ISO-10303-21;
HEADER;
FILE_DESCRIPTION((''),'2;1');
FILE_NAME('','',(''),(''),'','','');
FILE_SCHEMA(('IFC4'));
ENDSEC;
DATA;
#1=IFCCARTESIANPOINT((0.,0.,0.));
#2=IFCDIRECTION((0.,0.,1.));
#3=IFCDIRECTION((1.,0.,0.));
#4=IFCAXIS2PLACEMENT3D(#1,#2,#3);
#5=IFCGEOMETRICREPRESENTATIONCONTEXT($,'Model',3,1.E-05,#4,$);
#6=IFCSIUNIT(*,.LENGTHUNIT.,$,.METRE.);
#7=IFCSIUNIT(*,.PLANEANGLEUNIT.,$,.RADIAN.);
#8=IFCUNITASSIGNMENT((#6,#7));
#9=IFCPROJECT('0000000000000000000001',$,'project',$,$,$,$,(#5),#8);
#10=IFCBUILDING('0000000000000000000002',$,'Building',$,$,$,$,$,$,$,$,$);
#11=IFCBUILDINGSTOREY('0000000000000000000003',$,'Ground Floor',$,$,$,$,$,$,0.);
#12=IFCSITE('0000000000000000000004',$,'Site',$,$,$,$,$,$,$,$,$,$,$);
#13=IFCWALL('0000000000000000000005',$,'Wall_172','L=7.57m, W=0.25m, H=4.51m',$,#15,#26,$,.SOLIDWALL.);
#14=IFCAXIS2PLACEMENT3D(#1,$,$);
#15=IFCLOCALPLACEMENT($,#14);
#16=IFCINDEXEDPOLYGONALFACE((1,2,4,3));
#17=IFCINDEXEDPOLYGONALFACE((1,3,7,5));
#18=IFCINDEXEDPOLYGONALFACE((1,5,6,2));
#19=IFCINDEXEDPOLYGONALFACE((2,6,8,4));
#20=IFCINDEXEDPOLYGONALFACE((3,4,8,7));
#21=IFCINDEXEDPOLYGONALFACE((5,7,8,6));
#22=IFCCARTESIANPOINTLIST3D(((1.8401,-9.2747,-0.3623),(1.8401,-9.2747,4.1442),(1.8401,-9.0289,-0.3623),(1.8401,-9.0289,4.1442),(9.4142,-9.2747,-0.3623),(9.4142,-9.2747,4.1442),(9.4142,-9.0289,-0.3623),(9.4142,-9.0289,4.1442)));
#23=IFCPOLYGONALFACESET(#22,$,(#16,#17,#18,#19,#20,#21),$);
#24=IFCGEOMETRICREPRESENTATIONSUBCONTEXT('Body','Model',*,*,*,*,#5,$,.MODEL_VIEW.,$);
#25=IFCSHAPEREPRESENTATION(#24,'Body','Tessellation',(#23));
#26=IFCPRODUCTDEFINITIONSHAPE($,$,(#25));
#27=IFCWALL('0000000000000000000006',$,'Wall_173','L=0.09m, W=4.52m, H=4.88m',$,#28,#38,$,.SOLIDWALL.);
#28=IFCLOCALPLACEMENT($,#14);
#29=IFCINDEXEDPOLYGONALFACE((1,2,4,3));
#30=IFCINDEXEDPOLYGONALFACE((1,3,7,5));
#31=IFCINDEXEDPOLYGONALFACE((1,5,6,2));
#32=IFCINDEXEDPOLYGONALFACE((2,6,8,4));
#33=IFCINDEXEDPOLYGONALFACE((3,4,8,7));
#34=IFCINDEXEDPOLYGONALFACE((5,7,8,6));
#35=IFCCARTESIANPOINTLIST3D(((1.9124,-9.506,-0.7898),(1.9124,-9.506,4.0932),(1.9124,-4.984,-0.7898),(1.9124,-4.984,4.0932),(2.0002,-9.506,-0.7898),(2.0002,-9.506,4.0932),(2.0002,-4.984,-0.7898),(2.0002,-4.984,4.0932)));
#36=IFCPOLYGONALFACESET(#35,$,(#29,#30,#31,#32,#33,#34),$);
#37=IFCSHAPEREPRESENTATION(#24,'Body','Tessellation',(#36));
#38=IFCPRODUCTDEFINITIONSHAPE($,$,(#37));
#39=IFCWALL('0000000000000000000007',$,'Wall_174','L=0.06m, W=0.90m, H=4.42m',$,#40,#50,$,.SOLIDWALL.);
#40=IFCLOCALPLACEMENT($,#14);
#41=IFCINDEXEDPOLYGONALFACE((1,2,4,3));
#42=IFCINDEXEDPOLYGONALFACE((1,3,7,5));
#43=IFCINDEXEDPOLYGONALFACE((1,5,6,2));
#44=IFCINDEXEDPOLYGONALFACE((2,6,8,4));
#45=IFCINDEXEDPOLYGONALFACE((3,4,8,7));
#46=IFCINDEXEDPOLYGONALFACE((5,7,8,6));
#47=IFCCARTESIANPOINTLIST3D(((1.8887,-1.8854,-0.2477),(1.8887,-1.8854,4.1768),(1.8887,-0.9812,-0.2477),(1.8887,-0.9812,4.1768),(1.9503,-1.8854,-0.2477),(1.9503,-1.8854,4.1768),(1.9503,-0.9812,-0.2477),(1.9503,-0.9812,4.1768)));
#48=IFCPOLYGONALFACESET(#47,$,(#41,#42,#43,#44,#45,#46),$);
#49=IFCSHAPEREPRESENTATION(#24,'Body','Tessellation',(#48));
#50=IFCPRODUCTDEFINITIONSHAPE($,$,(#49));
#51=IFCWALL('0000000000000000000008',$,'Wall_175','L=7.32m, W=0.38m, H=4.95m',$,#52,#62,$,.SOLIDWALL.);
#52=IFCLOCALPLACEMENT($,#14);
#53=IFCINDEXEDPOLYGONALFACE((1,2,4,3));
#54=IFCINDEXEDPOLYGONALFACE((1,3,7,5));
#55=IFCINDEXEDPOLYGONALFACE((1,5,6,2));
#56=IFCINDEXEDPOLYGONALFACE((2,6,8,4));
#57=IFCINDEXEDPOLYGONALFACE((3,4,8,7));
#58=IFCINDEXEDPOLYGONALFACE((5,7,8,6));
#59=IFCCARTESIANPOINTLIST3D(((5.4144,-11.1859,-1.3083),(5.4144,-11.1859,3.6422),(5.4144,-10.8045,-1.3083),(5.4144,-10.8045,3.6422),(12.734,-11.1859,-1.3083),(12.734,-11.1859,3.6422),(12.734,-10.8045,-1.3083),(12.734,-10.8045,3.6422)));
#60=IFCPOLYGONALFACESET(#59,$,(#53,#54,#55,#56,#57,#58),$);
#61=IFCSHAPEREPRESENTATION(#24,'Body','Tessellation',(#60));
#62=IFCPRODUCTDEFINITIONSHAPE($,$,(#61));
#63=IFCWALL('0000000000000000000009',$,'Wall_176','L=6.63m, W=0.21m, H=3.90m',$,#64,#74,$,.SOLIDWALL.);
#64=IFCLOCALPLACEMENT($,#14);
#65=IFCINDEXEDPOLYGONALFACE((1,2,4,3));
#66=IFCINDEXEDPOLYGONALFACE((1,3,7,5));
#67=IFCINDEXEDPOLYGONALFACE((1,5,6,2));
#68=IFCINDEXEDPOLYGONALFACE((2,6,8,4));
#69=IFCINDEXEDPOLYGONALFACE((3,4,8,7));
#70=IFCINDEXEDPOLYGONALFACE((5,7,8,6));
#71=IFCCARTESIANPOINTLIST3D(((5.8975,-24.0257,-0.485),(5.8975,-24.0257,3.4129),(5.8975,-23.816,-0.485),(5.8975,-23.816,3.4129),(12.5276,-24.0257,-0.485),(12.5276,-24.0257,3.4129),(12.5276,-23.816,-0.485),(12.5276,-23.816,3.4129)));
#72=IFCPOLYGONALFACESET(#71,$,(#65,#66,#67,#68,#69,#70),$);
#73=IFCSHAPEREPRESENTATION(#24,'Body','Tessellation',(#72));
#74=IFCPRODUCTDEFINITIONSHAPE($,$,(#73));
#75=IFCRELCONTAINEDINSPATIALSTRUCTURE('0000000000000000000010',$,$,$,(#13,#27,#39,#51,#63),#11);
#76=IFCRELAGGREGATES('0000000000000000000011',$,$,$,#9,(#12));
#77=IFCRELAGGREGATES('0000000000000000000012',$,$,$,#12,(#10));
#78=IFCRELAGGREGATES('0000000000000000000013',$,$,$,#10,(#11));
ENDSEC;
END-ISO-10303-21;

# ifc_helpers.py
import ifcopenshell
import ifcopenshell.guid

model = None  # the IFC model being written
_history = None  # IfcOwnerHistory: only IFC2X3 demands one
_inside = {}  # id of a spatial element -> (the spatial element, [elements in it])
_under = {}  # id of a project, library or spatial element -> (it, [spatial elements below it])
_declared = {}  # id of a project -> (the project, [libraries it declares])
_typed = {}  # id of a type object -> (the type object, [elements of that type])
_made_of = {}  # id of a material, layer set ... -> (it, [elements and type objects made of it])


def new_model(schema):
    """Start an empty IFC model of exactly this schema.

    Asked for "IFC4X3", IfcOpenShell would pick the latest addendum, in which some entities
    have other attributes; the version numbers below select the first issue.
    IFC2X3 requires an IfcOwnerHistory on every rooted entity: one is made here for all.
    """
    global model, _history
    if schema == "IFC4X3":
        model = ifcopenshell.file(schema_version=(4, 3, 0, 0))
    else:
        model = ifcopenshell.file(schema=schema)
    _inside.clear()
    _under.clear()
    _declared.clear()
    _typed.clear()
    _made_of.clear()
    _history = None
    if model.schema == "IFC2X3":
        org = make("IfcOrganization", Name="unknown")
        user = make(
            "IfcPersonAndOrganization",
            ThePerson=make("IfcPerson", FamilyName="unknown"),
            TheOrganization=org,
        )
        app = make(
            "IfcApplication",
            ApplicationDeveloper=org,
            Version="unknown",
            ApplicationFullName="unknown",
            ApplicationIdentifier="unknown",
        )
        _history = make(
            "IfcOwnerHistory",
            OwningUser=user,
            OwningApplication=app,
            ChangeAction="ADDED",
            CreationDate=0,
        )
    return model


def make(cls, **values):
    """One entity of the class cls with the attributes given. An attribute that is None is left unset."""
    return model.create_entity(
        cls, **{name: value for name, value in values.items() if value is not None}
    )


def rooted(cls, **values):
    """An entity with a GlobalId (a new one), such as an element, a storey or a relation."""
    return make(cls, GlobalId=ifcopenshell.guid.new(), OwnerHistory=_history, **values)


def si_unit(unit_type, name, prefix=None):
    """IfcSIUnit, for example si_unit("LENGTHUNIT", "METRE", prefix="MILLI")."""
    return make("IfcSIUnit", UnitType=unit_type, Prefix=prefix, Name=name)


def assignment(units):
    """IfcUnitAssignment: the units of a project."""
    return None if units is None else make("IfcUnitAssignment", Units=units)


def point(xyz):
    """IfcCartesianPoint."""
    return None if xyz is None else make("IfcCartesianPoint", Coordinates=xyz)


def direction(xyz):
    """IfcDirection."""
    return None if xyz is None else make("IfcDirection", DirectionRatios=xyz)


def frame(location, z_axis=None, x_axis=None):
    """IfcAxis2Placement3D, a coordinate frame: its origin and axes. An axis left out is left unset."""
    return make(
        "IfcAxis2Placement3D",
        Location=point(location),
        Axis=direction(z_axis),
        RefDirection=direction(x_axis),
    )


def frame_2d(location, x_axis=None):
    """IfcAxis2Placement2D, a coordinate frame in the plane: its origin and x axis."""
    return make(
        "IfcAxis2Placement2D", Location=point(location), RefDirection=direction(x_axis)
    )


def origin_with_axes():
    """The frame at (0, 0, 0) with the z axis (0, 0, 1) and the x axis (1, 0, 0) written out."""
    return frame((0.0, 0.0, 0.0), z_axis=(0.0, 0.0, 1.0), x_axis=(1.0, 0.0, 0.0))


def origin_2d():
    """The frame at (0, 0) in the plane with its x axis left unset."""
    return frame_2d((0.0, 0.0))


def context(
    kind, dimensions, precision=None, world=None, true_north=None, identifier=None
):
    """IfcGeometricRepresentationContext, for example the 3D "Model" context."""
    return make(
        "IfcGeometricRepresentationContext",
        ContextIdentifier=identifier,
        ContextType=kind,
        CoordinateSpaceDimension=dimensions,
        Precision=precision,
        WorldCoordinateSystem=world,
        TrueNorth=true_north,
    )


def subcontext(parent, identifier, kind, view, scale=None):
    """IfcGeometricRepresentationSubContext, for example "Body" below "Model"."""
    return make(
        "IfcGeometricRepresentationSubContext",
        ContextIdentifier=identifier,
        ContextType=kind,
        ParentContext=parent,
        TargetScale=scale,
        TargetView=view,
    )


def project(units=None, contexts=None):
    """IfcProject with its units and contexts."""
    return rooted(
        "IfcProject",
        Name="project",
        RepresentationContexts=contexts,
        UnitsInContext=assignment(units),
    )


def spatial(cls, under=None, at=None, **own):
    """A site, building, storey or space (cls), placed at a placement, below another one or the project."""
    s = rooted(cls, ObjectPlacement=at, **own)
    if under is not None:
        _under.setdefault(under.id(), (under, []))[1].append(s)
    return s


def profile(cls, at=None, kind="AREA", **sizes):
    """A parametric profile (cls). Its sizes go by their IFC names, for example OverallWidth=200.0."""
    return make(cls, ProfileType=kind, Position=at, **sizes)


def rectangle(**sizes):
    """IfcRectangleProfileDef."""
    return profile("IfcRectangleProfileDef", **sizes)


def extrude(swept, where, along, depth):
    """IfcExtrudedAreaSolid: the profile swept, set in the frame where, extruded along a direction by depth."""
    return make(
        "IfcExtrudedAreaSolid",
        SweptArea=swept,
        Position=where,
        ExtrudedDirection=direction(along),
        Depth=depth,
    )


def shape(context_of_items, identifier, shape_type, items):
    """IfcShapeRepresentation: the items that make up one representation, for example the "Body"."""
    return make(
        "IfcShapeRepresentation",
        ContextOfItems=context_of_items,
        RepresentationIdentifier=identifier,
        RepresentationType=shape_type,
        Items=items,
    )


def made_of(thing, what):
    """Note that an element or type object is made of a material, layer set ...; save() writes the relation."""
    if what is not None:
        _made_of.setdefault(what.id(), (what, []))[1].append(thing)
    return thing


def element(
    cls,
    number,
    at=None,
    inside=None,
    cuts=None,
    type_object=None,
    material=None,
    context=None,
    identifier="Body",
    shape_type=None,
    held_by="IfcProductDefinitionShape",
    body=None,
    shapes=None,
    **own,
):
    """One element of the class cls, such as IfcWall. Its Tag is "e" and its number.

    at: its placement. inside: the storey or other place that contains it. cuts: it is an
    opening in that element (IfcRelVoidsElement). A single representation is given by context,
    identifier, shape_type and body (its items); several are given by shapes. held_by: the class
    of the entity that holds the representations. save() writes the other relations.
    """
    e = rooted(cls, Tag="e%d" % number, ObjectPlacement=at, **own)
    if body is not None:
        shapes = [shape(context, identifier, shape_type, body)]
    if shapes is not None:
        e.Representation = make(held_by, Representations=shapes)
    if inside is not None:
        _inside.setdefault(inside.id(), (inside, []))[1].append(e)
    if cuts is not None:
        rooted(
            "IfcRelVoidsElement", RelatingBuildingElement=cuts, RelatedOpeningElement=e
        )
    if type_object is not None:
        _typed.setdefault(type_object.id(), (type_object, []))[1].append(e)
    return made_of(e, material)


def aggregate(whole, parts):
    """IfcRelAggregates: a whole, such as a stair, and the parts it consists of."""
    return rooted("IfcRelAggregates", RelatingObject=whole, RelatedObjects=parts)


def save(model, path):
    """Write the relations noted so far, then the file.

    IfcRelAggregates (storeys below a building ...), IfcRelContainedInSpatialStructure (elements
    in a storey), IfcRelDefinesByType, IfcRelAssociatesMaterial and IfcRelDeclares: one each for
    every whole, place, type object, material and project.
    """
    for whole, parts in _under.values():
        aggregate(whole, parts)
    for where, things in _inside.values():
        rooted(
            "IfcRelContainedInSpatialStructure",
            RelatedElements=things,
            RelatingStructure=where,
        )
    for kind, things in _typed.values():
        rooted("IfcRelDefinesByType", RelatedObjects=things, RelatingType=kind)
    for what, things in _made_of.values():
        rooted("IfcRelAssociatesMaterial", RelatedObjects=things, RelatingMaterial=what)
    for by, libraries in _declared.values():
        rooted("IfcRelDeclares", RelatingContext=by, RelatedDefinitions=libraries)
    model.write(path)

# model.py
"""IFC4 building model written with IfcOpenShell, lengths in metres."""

from ifc_helpers import new_model, si_unit, frame, origin_with_axes, origin_2d, context, subcontext, project, spatial, rectangle, extrude, element, save


model = new_model("IFC4")

# Units and contexts
model_context = context("Model", 3, precision=1e-05, world=origin_with_axes())
body_context = subcontext(model_context, "Body", "Model", "MODEL_VIEW")
ifc_project = project(units=[si_unit("LENGTHUNIT", "METRE"), si_unit("PLANEANGLEUNIT", "RADIAN")], contexts=[model_context])

# Site, building, storey
site = spatial("IfcSite", under=ifc_project, Name="Site")
building = spatial("IfcBuilding", under=site, Name="Building")
storey = spatial("IfcBuildingStorey", under=building, Name="Ground Floor", Elevation=0.0)

# Walls
element("IfcWall", 1, inside=storey, Name="Wall_172", Description="L=7.57m, W=0.25m, H=4.51m", PredefinedType="SOLIDWALL", context=body_context, shape_type="SweptSolid", body=[
    extrude(rectangle(XDim=7.574, YDim=0.2458, at=origin_2d()), frame((5.6272, -9.1518, -0.3623), z_axis=(0.0, 0.0, 1.0), x_axis=(1.0, 0.0, 0.0)), (0.0, 0.0, 1.0), 4.5066),
])
element("IfcWall", 2, inside=storey, Name="Wall_173", Description="L=0.09m, W=4.52m, H=4.88m", PredefinedType="SOLIDWALL", context=body_context, shape_type="SweptSolid", body=[
    extrude(rectangle(XDim=0.0879, YDim=4.522, at=origin_2d()), frame((1.9563, -7.245, -0.7898), z_axis=(0.0, 0.0, 1.0), x_axis=(1.0, 0.0, 0.0)), (0.0, 0.0, 1.0), 4.883),
])
element("IfcWall", 3, inside=storey, Name="Wall_174", Description="L=0.06m, W=0.90m, H=4.42m", PredefinedType="SOLIDWALL", context=body_context, shape_type="SweptSolid", body=[
    extrude(rectangle(XDim=0.0616, YDim=0.9042, at=origin_2d()), frame((1.9195, -1.4333, -0.2477), z_axis=(0.0, 0.0, 1.0), x_axis=(1.0, 0.0, 0.0)), (0.0, 0.0, 1.0), 4.4245),
])
element("IfcWall", 4, inside=storey, Name="Wall_175", Description="L=7.32m, W=0.38m, H=4.95m", PredefinedType="SOLIDWALL", context=body_context, shape_type="SweptSolid", body=[
    extrude(rectangle(XDim=7.3196, YDim=0.3814, at=origin_2d()), frame((9.0742, -10.9952, -1.3083), z_axis=(0.0, 0.0, 1.0), x_axis=(1.0, 0.0, 0.0)), (0.0, 0.0, 1.0), 4.9505),
])
element("IfcWall", 5, inside=storey, Name="Wall_176", Description="L=6.63m, W=0.21m, H=3.90m", PredefinedType="SOLIDWALL", context=body_context, shape_type="SweptSolid", body=[
    extrude(rectangle(XDim=6.6301, YDim=0.2098, at=origin_2d()), frame((9.2125, -23.9209, -0.485), z_axis=(0.0, 0.0, 1.0), x_axis=(1.0, 0.0, 0.0)), (0.0, 0.0, 1.0), 3.8979),
])

save(model, "model.ifc")
